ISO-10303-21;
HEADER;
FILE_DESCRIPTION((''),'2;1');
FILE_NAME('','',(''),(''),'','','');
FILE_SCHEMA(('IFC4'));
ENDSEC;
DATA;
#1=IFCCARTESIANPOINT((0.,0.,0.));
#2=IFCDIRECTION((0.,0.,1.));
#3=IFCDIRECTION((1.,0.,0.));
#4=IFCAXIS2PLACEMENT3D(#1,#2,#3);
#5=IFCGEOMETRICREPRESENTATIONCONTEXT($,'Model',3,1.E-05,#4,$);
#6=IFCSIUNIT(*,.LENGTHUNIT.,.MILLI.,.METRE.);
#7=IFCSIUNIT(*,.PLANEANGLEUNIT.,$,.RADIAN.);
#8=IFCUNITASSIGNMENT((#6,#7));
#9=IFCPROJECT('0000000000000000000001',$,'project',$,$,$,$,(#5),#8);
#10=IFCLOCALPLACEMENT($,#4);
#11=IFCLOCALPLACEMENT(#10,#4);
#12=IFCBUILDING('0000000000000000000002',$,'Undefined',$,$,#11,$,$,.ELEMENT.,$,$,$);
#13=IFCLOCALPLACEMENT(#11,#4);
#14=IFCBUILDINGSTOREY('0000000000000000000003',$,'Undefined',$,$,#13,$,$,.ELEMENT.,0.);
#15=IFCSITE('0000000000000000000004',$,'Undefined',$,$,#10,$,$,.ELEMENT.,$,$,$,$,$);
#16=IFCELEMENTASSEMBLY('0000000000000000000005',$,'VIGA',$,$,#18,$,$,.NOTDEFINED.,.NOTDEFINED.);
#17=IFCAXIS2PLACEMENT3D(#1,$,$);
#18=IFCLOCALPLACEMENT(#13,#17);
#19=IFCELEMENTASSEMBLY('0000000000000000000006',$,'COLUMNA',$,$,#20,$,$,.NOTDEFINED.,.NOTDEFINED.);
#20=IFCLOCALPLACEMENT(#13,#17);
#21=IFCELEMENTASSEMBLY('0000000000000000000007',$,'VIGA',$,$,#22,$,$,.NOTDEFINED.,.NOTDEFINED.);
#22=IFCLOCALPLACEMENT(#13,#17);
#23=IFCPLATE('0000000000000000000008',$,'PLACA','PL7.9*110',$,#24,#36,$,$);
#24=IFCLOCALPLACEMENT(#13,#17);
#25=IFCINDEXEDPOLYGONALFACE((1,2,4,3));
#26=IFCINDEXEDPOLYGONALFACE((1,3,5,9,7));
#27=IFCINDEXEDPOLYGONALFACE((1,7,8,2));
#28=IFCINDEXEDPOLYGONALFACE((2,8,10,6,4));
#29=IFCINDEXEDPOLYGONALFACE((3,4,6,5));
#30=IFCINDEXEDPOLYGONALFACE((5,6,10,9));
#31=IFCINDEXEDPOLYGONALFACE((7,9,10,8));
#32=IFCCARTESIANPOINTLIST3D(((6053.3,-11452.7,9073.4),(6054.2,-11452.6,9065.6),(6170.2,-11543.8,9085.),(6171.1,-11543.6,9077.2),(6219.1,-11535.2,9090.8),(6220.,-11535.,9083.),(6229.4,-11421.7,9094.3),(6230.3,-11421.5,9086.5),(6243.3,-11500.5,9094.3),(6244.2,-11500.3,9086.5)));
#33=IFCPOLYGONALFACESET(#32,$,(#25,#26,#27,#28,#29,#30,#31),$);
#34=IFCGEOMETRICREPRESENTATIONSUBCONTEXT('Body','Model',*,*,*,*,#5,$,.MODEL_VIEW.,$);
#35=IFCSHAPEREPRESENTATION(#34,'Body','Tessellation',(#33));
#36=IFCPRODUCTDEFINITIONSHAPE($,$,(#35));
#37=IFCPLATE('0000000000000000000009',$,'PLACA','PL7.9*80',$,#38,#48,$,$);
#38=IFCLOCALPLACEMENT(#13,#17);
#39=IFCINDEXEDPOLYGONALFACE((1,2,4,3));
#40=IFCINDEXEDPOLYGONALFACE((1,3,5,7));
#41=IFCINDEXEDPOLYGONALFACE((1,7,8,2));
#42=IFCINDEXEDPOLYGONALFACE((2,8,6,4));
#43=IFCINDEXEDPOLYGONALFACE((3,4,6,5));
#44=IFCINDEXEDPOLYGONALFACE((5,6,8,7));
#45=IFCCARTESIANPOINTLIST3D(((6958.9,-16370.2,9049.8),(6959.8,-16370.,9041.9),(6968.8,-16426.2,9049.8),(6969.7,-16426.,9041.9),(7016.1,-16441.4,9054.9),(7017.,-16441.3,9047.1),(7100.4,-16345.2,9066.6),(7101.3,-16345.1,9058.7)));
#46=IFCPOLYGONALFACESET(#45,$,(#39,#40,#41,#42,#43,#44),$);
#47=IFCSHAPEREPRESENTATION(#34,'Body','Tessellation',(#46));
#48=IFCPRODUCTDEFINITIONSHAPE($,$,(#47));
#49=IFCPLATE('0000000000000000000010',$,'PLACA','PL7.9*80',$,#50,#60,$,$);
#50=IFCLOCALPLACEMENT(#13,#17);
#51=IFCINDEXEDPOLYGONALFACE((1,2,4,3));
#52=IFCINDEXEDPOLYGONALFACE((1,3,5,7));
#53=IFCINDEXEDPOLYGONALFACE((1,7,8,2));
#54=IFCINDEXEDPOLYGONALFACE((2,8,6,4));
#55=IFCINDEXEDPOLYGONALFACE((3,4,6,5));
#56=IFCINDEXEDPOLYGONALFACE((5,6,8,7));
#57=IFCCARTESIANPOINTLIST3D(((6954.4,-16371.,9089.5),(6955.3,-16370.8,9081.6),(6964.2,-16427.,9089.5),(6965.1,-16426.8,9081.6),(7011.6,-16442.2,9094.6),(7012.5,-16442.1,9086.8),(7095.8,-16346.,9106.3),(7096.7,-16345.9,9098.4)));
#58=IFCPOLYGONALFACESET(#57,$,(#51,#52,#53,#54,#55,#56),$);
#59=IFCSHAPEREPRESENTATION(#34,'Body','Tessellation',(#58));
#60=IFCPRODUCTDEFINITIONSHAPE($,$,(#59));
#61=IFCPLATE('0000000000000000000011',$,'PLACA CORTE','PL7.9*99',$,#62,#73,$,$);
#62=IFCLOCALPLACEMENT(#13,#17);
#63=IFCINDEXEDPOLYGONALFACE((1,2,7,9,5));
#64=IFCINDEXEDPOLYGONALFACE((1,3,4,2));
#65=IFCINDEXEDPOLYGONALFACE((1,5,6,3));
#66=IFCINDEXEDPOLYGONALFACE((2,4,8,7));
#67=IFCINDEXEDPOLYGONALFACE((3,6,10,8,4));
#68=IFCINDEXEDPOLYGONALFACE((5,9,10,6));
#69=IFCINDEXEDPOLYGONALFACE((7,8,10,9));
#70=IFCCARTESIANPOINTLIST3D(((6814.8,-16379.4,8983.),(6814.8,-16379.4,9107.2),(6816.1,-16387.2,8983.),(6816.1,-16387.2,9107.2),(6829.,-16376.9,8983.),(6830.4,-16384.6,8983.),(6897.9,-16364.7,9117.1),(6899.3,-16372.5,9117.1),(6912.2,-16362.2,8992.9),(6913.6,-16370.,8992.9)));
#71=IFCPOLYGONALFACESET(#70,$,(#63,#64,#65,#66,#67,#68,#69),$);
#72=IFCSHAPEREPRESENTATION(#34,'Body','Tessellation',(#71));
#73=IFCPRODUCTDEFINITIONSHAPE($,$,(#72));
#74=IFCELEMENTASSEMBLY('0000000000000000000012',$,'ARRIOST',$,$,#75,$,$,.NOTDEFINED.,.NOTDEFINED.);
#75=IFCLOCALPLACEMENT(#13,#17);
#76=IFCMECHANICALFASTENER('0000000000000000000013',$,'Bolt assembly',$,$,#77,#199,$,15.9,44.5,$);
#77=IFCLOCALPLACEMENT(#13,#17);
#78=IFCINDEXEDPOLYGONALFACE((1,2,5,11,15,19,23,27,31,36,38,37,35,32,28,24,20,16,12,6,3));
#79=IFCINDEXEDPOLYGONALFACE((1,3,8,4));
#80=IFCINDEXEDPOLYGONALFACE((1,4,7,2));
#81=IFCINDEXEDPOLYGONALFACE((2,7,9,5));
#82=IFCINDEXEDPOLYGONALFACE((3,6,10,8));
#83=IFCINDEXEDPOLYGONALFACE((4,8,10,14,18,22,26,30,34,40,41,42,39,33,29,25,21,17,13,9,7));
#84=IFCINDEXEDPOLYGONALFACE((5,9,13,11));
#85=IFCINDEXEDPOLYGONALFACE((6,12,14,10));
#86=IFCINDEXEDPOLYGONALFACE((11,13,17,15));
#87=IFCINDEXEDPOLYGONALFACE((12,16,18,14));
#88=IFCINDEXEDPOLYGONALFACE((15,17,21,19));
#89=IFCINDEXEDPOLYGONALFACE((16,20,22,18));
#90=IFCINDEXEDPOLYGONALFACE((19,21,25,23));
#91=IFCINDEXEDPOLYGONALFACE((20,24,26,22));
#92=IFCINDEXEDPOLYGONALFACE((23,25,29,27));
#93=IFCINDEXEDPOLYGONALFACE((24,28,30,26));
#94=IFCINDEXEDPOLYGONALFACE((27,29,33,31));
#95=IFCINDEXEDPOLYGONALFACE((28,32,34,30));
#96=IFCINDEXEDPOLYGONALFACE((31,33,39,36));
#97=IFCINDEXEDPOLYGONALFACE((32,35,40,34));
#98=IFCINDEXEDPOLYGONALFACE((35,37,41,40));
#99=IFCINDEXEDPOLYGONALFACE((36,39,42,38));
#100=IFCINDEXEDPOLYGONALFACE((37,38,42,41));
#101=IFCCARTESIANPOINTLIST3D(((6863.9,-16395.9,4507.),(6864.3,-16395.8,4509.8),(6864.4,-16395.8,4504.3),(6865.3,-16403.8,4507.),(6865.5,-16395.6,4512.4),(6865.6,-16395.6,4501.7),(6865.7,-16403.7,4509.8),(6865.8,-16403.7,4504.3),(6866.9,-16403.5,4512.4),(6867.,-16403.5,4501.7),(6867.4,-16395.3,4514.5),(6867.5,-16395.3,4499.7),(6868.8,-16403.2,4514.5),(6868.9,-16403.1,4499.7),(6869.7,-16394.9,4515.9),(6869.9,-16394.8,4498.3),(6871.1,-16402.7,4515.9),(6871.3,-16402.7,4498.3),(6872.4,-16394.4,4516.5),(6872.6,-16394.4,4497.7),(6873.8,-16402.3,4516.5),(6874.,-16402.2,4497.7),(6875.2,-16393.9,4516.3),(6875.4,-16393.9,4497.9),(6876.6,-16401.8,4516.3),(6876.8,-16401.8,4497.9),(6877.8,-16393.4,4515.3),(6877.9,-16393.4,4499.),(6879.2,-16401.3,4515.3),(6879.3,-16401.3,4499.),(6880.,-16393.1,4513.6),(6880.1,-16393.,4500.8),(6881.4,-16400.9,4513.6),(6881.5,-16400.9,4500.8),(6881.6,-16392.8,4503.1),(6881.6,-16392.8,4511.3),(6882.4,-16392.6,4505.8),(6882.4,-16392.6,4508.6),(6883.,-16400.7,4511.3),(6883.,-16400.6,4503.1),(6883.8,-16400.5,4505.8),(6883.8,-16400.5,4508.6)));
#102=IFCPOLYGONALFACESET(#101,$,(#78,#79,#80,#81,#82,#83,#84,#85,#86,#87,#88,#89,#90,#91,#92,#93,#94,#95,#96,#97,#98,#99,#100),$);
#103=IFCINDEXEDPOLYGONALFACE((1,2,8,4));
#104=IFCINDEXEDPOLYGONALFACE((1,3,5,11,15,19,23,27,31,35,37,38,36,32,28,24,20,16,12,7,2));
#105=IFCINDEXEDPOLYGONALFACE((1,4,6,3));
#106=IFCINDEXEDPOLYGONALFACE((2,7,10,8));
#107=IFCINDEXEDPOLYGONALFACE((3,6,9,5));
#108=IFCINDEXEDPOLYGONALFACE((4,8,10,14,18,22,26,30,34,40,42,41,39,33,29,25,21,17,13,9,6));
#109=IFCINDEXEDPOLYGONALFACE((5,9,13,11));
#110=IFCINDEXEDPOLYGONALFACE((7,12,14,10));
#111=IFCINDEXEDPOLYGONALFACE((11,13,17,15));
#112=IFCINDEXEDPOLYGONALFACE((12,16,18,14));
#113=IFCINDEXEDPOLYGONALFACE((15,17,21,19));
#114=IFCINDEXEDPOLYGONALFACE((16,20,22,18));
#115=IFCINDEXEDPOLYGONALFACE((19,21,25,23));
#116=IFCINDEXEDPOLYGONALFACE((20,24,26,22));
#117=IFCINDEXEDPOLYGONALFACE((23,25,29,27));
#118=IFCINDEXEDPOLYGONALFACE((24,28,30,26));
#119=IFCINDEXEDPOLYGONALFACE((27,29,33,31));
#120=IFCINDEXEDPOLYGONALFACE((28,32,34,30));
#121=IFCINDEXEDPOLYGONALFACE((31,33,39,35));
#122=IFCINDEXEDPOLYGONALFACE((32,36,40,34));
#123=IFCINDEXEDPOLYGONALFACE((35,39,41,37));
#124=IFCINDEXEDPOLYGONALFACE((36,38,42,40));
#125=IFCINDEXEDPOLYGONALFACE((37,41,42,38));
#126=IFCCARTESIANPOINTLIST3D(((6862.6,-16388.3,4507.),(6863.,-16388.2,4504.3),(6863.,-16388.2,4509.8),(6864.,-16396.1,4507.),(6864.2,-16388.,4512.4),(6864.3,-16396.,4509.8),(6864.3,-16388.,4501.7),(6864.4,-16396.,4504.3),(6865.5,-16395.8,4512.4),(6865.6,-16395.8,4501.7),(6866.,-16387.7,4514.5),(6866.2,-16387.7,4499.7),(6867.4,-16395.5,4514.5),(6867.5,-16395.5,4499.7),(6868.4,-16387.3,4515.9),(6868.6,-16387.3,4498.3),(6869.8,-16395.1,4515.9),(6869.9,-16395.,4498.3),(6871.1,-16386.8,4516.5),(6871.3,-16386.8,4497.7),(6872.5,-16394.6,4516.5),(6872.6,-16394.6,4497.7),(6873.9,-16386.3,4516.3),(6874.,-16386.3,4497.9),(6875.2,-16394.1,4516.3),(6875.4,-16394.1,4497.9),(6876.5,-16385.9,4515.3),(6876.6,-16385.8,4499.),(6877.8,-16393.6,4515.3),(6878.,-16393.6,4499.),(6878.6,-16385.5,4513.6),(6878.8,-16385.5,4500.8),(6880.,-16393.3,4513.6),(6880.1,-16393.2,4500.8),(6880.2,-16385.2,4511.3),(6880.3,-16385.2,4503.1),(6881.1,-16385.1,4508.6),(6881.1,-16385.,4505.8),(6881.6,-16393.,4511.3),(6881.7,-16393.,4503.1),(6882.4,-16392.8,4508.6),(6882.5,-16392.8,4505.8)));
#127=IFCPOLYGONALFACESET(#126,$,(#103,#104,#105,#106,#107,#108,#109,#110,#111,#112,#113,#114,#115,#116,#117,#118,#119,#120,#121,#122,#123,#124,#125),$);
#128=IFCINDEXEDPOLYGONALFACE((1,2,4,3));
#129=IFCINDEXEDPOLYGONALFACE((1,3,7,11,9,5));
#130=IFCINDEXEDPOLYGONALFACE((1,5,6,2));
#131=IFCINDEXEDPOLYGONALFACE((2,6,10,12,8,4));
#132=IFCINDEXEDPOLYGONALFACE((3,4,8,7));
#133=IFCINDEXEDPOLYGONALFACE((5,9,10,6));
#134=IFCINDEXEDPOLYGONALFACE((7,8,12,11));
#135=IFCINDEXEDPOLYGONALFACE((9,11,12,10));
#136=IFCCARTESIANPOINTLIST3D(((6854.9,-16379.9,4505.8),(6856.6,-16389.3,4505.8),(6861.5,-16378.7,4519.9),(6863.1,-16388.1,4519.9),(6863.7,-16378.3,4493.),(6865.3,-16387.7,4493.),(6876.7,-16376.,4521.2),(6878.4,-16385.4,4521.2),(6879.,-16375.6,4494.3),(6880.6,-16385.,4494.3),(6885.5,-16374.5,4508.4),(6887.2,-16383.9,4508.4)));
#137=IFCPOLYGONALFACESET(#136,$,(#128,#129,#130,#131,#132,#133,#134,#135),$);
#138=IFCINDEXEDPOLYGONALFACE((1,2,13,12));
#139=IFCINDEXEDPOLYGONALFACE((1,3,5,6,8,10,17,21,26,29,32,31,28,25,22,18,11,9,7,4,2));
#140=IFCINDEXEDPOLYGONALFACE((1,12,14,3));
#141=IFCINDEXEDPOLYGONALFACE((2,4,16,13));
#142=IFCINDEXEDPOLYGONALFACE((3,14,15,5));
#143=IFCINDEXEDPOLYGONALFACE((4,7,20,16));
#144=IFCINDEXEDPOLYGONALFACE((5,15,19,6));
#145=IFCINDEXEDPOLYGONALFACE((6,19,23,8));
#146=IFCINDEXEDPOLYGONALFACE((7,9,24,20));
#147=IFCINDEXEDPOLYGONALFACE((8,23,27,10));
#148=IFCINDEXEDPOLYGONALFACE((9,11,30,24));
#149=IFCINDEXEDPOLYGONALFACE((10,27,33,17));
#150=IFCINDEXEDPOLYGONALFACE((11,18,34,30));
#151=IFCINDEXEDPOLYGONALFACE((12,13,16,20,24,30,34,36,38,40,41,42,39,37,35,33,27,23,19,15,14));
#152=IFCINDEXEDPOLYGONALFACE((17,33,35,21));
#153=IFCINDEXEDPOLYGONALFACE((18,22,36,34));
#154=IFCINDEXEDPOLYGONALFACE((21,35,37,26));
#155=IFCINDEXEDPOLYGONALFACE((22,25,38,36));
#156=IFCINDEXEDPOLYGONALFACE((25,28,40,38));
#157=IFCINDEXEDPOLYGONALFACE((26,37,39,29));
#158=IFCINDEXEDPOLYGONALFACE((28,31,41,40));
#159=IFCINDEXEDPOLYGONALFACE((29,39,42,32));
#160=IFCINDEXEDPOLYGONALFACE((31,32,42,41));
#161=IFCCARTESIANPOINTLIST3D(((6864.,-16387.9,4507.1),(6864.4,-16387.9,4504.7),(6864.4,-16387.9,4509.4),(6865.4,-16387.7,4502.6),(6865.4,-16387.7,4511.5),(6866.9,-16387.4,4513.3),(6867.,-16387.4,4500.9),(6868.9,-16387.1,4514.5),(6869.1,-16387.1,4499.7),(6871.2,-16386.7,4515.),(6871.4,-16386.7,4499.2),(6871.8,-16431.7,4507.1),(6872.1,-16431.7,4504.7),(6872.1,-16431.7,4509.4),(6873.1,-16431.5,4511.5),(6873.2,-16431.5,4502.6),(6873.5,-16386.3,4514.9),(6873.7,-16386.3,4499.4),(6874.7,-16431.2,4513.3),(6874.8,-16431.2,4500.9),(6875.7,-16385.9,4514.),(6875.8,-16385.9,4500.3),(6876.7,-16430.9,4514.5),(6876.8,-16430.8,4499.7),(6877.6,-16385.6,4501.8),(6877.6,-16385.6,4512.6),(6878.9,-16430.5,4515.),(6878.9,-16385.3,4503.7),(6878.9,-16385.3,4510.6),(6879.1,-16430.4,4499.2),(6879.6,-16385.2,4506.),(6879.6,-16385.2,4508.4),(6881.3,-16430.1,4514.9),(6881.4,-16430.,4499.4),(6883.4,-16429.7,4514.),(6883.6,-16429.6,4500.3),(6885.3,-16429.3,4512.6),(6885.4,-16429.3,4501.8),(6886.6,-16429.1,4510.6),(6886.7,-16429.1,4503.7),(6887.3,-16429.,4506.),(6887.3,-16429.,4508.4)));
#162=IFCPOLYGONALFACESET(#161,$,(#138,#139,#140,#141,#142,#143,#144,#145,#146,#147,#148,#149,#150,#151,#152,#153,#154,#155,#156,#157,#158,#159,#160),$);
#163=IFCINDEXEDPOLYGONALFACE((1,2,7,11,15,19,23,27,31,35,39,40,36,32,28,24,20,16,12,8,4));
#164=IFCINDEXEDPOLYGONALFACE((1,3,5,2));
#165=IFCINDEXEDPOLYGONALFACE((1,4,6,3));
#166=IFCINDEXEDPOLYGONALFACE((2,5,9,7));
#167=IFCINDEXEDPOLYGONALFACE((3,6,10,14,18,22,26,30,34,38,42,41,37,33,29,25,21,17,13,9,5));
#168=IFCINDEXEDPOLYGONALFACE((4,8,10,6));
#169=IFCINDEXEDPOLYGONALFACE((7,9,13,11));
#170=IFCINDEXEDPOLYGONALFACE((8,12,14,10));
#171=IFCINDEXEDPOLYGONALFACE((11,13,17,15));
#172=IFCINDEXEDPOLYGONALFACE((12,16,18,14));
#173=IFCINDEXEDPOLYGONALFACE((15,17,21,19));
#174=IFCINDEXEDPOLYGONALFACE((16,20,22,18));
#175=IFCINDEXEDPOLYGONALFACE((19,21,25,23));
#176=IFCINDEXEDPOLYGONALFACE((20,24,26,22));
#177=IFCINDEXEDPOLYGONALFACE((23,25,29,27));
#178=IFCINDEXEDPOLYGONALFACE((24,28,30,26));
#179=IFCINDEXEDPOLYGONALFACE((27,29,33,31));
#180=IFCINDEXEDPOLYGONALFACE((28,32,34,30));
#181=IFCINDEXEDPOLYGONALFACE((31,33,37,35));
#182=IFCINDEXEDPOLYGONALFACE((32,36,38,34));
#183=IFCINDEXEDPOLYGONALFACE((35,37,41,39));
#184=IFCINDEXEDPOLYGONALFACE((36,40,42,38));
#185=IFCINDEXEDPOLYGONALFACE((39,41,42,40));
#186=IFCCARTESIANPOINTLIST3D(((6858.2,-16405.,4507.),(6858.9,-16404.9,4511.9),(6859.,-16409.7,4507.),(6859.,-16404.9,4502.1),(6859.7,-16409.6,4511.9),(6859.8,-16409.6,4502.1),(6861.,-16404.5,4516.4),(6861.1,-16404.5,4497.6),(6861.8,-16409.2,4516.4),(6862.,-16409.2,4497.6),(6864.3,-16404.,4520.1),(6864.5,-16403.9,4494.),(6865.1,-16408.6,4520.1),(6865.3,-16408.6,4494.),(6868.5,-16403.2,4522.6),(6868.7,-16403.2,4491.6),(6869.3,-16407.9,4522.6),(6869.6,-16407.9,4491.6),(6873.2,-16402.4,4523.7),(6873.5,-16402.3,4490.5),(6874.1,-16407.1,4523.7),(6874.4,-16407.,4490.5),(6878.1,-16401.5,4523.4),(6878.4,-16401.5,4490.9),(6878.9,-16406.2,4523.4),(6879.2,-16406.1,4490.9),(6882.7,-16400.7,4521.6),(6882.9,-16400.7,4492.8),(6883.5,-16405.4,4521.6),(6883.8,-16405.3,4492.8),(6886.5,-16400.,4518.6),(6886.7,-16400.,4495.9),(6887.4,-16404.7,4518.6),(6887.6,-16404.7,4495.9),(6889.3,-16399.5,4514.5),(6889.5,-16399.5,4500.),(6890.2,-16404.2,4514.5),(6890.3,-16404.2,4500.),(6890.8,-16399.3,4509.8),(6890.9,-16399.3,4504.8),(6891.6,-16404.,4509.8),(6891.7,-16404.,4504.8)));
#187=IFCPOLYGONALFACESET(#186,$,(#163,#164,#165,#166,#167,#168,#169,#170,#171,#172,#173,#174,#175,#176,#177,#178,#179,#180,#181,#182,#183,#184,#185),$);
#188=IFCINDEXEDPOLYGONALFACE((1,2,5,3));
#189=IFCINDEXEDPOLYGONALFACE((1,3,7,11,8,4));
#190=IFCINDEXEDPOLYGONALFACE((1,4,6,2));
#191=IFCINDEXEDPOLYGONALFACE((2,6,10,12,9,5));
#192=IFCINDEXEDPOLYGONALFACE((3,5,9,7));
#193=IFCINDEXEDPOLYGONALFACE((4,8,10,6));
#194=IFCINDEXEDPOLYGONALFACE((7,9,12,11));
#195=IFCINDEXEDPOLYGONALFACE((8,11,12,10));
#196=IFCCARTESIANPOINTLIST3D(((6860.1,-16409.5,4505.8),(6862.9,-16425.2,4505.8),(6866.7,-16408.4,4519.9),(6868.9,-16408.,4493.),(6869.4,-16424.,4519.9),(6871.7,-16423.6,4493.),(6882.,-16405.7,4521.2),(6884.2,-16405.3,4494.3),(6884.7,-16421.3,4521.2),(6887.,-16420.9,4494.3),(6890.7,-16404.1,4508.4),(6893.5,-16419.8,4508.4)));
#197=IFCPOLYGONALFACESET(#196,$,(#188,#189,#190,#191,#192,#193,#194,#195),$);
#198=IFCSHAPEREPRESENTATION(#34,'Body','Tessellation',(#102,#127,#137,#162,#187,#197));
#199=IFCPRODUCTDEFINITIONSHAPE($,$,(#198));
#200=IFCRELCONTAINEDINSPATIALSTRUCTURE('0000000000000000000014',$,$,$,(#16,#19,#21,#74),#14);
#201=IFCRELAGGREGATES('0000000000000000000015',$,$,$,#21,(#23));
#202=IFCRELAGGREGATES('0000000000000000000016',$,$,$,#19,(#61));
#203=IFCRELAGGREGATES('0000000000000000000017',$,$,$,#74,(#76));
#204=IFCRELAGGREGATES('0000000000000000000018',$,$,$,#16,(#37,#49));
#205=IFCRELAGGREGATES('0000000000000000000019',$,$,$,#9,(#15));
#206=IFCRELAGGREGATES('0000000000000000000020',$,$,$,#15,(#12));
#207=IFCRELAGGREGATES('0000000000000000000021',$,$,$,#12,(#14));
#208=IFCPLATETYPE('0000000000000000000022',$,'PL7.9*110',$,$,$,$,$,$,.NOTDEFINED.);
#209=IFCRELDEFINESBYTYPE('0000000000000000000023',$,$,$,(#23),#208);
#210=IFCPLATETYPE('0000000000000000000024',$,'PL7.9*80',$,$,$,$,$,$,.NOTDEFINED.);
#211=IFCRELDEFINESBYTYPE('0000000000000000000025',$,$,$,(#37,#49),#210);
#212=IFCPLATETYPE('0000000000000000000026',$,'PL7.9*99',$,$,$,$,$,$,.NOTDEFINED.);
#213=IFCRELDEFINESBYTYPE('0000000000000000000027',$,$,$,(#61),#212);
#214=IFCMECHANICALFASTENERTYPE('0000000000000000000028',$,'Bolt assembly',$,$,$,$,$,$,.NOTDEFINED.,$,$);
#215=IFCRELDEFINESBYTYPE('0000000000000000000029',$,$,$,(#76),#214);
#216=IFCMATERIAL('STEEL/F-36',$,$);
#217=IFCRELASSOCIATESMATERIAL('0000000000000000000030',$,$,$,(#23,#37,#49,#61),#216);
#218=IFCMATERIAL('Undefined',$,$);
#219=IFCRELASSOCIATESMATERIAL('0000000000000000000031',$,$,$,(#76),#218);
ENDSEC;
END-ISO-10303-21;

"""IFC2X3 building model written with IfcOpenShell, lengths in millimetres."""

from ifc_helpers import new_model, si_unit, frame, origin_with_axes, origin_2d_with_axis, place, context, subcontext, project, spatial, polyline, circle, outline, extrude, source, transform, mapped, material, type_object, element, aggregate, save


model = new_model("IFC2X3")

# Units and contexts
model_context = context("Model", 3, precision=1e-05, world=origin_with_axes())
body_context = subcontext(model_context, "Body", "Model", "MODEL_VIEW")
ifc_project = project(units=[si_unit("LENGTHUNIT", "METRE", prefix="MILLI"), si_unit("PLANEANGLEUNIT", "RADIAN")], contexts=[model_context])

# Site, building, storey
site_placement = place(None, origin_with_axes())
site = spatial("IfcSite", under=ifc_project, at=site_placement, Name="Undefined", CompositionType="ELEMENT")
building_placement = place(site_placement, origin_with_axes())
building = spatial("IfcBuilding", under=site, at=building_placement, Name="Undefined", CompositionType="ELEMENT")
storey_placement = place(building_placement, origin_with_axes())
storey = spatial("IfcBuildingStorey", under=building, at=storey_placement, Name="Undefined", CompositionType="ELEMENT", Elevation=0.0)

# Element assembly
assembly_1_placement = place(storey_placement, origin_with_axes())
assembly_1 = element("IfcElementAssembly", 1, at=assembly_1_placement, inside=storey, Name="VIGA", AssemblyPlace="NOTDEFINED", PredefinedType="NOTDEFINED")

# Shared definitions
ifc_material_1 = material(Name="STEEL/F-36")

# Element assembly
assembly_2_placement = place(storey_placement, origin_with_axes())
assembly_2 = element("IfcElementAssembly", 2, at=assembly_2_placement, inside=storey, Name="COLUMNA", AssemblyPlace="NOTDEFINED", PredefinedType="NOTDEFINED")

# Element assembly, plate
assembly_3_placement = place(storey_placement, origin_with_axes())
assembly_3 = element("IfcElementAssembly", 3, at=assembly_3_placement, inside=storey, Name="VIGA", AssemblyPlace="NOTDEFINED", PredefinedType="NOTDEFINED")
plate_type_1 = type_object("IfcPlateType", Name="PL7.9*110", PredefinedType="NOTDEFINED")
plate_1_placement = place(assembly_3_placement, frame((6170.7, -11543.7, 9081.1), z_axis=(0.114445, 0.02018, -0.993225), x_axis=(-0.786454, 0.612682, -0.078171)))
plate_1 = element("IfcPlate", 4, at=plate_1_placement, type_object=plate_type_1, material=ifc_material_1, Name="PLACA", Description="PL7.9*110", context=body_context, shape_type="SweptSolid", body=[
    extrude(outline(polyline([(0.0, 0.0), (148.7, 0.0), (27.6, 133.2), (-31.6, 79.4), (-33.6, 37.0), (0.0, 0.0)])), frame((0.0, 0.0, -4.0), z_axis=(0.0, 0.0, 1.0), x_axis=(1.0, 0.0, 0.0)), (0.0, 0.0, 1.0), 7.9),
])
aggregate(assembly_3, [plate_1])

# Plates
plate_type_2 = type_object("IfcPlateType", Name="PL7.9*80", PredefinedType="NOTDEFINED")
plate_2_placement = place(assembly_1_placement, frame((6959.4, -16370.1, 9045.8), z_axis=(-0.114331, -0.020154, 0.993238), x_axis=(0.173566, -0.984822, -0.000004)))
plate_2 = element("IfcPlate", 5, at=plate_2_placement, type_object=plate_type_2, material=ifc_material_1, Name="PLACA", Description="PL7.9*80", context=body_context, shape_type="SweptSolid", body=[
    extrude(outline(polyline([(0.0, 0.0), (56.9, 0.0), (80.1, 44.3), (0.0, 144.6), (0.0, 0.0)])), frame((0.0, 0.0, -4.0), z_axis=(0.0, 0.0, 1.0), x_axis=(1.0, 0.0, 0.0)), (0.0, 0.0, 1.0), 7.9),
])
plate_3_placement = place(assembly_1_placement, frame((6954.8, -16370.9, 9085.6), z_axis=(-0.114333, -0.020159, 0.993238), x_axis=(0.173567, -0.984822, -0.000009)))
plate_3 = element("IfcPlate", 6, at=plate_3_placement, type_object=plate_type_2, material=ifc_material_1, Name="PLACA", Description="PL7.9*80", context=body_context, shape_type="SweptSolid", body=[
    extrude(outline(polyline([(0.0, 0.0), (56.9, 0.0), (80.1, 44.3), (0.0, 144.6), (0.0, 0.0)])), frame((0.0, 0.0, -4.0), z_axis=(0.0, 0.0, 1.0), x_axis=(1.0, 0.0, 0.0)), (0.0, 0.0, 1.0), 7.9),
])
plate_type_3 = type_object("IfcPlateType", Name="PL7.9*99", PredefinedType="NOTDEFINED")
plate_4_placement = place(assembly_2_placement, frame((6815.4, -16383.3, 9107.2), z_axis=(-0.173645, 0.984808, 0.0), x_axis=(0.978149, 0.172472, 0.116092)))
plate_4 = element("IfcPlate", 7, at=plate_4_placement, type_object=plate_type_3, material=ifc_material_1, Name="PLACA CORTE", Description="PL7.9*99", context=body_context, shape_type="SweptSolid", body=[
    extrude(outline(polyline([(0.0, 0.0), (85.0, 0.0), (85.0, 125.0), (0.0, 125.0), (-14.4, 123.3), (0.0, 0.0)])), frame((0.0, 0.0, -4.0), z_axis=(0.0, 0.0, 1.0), x_axis=(1.0, 0.0, 0.0)), (0.0, 0.0, 1.0), 7.9),
])
aggregate(assembly_2, [plate_4])

# Element assembly, mechanical fastener
assembly_4_placement = place(storey_placement, origin_with_axes())
assembly_4 = element("IfcElementAssembly", 8, at=assembly_4_placement, inside=storey, Name="ARRIOST", AssemblyPlace="NOTDEFINED", PredefinedType="NOTDEFINED")
ifc_material_2 = material(Name="Undefined")
mechanical_fastener_type = type_object("IfcMechanicalFastenerType", Name="Bolt assembly")
shared_shape_1 = source(origin_with_axes(), body_context, "Body", "SweptSolid", [
    extrude(circle(Radius=9.4, at=origin_2d_with_axis()), frame((0.0, 3.8, 0.0), z_axis=(0.0, 1.0, 0.0), x_axis=(1.0, 0.0, 0.0)), (0.0, 0.0, 1.0), 8.0),
    extrude(circle(Radius=9.4, at=origin_2d_with_axis()), frame((0.0, -3.9, 0.0), z_axis=(0.0, 1.0, 0.0), x_axis=(1.0, 0.0, 0.0)), (0.0, 0.0, 1.0), 7.9),
    extrude(outline(polyline([(13.5, -7.8), (13.5, 7.8), (0.0, 15.6), (-13.5, 7.8), (-13.5, -7.8), (0.0, -15.6), (13.5, -7.8)])), frame((0.0, -13.5, 0.0), z_axis=(0.0, 1.0, 0.0), x_axis=(1.0, 0.0, 0.0)), (0.0, 0.0, 1.0), 9.5),
    extrude(circle(Radius=7.9, at=origin_2d_with_axis()), frame((0.0, -4.0, 0.0), z_axis=(0.0, 1.0, 0.0), x_axis=(1.0, 0.0, 0.0)), (0.0, 0.0, 1.0), 44.5),
    extrude(circle(Radius=16.7, at=origin_2d_with_axis()), frame((0.0, 11.8, 0.0), z_axis=(0.0, 1.0, 0.0), x_axis=(1.0, 0.0, 0.0)), (0.0, 0.0, 1.0), 4.8),
    extrude(outline(polyline([(13.5, -7.8), (13.5, 7.8), (0.0, 15.6), (-13.5, 7.8), (-13.5, -7.8), (0.0, -15.6), (13.5, -7.8)])), frame((0.0, 16.6, 0.0), z_axis=(0.0, 1.0, 0.0), x_axis=(1.0, 0.0, 0.0)), (0.0, 0.0, 1.0), 15.9),
])
mechanical_fastener_1_placement = place(assembly_4_placement, frame((6872.6, -16390.5, 4507.1), z_axis=(-0.419438, -0.073957, -0.904766), x_axis=(0.891021, 0.157109, -0.425908)))
mechanical_fastener_1 = element("IfcMechanicalFastener", 9, at=mechanical_fastener_1_placement, type_object=mechanical_fastener_type, material=ifc_material_2, Name="Bolt assembly", NominalDiameter=15.9, NominalLength=44.5, context=body_context, shape_type="MappedRepresentation", body=[
    mapped(shared_shape_1, transform((0.0, 0.0, 0.0))),
])
aggregate(assembly_4, [mechanical_fastener_1])

aggregate(assembly_1, [plate_2, plate_3])

save(model, "model.ifc")
